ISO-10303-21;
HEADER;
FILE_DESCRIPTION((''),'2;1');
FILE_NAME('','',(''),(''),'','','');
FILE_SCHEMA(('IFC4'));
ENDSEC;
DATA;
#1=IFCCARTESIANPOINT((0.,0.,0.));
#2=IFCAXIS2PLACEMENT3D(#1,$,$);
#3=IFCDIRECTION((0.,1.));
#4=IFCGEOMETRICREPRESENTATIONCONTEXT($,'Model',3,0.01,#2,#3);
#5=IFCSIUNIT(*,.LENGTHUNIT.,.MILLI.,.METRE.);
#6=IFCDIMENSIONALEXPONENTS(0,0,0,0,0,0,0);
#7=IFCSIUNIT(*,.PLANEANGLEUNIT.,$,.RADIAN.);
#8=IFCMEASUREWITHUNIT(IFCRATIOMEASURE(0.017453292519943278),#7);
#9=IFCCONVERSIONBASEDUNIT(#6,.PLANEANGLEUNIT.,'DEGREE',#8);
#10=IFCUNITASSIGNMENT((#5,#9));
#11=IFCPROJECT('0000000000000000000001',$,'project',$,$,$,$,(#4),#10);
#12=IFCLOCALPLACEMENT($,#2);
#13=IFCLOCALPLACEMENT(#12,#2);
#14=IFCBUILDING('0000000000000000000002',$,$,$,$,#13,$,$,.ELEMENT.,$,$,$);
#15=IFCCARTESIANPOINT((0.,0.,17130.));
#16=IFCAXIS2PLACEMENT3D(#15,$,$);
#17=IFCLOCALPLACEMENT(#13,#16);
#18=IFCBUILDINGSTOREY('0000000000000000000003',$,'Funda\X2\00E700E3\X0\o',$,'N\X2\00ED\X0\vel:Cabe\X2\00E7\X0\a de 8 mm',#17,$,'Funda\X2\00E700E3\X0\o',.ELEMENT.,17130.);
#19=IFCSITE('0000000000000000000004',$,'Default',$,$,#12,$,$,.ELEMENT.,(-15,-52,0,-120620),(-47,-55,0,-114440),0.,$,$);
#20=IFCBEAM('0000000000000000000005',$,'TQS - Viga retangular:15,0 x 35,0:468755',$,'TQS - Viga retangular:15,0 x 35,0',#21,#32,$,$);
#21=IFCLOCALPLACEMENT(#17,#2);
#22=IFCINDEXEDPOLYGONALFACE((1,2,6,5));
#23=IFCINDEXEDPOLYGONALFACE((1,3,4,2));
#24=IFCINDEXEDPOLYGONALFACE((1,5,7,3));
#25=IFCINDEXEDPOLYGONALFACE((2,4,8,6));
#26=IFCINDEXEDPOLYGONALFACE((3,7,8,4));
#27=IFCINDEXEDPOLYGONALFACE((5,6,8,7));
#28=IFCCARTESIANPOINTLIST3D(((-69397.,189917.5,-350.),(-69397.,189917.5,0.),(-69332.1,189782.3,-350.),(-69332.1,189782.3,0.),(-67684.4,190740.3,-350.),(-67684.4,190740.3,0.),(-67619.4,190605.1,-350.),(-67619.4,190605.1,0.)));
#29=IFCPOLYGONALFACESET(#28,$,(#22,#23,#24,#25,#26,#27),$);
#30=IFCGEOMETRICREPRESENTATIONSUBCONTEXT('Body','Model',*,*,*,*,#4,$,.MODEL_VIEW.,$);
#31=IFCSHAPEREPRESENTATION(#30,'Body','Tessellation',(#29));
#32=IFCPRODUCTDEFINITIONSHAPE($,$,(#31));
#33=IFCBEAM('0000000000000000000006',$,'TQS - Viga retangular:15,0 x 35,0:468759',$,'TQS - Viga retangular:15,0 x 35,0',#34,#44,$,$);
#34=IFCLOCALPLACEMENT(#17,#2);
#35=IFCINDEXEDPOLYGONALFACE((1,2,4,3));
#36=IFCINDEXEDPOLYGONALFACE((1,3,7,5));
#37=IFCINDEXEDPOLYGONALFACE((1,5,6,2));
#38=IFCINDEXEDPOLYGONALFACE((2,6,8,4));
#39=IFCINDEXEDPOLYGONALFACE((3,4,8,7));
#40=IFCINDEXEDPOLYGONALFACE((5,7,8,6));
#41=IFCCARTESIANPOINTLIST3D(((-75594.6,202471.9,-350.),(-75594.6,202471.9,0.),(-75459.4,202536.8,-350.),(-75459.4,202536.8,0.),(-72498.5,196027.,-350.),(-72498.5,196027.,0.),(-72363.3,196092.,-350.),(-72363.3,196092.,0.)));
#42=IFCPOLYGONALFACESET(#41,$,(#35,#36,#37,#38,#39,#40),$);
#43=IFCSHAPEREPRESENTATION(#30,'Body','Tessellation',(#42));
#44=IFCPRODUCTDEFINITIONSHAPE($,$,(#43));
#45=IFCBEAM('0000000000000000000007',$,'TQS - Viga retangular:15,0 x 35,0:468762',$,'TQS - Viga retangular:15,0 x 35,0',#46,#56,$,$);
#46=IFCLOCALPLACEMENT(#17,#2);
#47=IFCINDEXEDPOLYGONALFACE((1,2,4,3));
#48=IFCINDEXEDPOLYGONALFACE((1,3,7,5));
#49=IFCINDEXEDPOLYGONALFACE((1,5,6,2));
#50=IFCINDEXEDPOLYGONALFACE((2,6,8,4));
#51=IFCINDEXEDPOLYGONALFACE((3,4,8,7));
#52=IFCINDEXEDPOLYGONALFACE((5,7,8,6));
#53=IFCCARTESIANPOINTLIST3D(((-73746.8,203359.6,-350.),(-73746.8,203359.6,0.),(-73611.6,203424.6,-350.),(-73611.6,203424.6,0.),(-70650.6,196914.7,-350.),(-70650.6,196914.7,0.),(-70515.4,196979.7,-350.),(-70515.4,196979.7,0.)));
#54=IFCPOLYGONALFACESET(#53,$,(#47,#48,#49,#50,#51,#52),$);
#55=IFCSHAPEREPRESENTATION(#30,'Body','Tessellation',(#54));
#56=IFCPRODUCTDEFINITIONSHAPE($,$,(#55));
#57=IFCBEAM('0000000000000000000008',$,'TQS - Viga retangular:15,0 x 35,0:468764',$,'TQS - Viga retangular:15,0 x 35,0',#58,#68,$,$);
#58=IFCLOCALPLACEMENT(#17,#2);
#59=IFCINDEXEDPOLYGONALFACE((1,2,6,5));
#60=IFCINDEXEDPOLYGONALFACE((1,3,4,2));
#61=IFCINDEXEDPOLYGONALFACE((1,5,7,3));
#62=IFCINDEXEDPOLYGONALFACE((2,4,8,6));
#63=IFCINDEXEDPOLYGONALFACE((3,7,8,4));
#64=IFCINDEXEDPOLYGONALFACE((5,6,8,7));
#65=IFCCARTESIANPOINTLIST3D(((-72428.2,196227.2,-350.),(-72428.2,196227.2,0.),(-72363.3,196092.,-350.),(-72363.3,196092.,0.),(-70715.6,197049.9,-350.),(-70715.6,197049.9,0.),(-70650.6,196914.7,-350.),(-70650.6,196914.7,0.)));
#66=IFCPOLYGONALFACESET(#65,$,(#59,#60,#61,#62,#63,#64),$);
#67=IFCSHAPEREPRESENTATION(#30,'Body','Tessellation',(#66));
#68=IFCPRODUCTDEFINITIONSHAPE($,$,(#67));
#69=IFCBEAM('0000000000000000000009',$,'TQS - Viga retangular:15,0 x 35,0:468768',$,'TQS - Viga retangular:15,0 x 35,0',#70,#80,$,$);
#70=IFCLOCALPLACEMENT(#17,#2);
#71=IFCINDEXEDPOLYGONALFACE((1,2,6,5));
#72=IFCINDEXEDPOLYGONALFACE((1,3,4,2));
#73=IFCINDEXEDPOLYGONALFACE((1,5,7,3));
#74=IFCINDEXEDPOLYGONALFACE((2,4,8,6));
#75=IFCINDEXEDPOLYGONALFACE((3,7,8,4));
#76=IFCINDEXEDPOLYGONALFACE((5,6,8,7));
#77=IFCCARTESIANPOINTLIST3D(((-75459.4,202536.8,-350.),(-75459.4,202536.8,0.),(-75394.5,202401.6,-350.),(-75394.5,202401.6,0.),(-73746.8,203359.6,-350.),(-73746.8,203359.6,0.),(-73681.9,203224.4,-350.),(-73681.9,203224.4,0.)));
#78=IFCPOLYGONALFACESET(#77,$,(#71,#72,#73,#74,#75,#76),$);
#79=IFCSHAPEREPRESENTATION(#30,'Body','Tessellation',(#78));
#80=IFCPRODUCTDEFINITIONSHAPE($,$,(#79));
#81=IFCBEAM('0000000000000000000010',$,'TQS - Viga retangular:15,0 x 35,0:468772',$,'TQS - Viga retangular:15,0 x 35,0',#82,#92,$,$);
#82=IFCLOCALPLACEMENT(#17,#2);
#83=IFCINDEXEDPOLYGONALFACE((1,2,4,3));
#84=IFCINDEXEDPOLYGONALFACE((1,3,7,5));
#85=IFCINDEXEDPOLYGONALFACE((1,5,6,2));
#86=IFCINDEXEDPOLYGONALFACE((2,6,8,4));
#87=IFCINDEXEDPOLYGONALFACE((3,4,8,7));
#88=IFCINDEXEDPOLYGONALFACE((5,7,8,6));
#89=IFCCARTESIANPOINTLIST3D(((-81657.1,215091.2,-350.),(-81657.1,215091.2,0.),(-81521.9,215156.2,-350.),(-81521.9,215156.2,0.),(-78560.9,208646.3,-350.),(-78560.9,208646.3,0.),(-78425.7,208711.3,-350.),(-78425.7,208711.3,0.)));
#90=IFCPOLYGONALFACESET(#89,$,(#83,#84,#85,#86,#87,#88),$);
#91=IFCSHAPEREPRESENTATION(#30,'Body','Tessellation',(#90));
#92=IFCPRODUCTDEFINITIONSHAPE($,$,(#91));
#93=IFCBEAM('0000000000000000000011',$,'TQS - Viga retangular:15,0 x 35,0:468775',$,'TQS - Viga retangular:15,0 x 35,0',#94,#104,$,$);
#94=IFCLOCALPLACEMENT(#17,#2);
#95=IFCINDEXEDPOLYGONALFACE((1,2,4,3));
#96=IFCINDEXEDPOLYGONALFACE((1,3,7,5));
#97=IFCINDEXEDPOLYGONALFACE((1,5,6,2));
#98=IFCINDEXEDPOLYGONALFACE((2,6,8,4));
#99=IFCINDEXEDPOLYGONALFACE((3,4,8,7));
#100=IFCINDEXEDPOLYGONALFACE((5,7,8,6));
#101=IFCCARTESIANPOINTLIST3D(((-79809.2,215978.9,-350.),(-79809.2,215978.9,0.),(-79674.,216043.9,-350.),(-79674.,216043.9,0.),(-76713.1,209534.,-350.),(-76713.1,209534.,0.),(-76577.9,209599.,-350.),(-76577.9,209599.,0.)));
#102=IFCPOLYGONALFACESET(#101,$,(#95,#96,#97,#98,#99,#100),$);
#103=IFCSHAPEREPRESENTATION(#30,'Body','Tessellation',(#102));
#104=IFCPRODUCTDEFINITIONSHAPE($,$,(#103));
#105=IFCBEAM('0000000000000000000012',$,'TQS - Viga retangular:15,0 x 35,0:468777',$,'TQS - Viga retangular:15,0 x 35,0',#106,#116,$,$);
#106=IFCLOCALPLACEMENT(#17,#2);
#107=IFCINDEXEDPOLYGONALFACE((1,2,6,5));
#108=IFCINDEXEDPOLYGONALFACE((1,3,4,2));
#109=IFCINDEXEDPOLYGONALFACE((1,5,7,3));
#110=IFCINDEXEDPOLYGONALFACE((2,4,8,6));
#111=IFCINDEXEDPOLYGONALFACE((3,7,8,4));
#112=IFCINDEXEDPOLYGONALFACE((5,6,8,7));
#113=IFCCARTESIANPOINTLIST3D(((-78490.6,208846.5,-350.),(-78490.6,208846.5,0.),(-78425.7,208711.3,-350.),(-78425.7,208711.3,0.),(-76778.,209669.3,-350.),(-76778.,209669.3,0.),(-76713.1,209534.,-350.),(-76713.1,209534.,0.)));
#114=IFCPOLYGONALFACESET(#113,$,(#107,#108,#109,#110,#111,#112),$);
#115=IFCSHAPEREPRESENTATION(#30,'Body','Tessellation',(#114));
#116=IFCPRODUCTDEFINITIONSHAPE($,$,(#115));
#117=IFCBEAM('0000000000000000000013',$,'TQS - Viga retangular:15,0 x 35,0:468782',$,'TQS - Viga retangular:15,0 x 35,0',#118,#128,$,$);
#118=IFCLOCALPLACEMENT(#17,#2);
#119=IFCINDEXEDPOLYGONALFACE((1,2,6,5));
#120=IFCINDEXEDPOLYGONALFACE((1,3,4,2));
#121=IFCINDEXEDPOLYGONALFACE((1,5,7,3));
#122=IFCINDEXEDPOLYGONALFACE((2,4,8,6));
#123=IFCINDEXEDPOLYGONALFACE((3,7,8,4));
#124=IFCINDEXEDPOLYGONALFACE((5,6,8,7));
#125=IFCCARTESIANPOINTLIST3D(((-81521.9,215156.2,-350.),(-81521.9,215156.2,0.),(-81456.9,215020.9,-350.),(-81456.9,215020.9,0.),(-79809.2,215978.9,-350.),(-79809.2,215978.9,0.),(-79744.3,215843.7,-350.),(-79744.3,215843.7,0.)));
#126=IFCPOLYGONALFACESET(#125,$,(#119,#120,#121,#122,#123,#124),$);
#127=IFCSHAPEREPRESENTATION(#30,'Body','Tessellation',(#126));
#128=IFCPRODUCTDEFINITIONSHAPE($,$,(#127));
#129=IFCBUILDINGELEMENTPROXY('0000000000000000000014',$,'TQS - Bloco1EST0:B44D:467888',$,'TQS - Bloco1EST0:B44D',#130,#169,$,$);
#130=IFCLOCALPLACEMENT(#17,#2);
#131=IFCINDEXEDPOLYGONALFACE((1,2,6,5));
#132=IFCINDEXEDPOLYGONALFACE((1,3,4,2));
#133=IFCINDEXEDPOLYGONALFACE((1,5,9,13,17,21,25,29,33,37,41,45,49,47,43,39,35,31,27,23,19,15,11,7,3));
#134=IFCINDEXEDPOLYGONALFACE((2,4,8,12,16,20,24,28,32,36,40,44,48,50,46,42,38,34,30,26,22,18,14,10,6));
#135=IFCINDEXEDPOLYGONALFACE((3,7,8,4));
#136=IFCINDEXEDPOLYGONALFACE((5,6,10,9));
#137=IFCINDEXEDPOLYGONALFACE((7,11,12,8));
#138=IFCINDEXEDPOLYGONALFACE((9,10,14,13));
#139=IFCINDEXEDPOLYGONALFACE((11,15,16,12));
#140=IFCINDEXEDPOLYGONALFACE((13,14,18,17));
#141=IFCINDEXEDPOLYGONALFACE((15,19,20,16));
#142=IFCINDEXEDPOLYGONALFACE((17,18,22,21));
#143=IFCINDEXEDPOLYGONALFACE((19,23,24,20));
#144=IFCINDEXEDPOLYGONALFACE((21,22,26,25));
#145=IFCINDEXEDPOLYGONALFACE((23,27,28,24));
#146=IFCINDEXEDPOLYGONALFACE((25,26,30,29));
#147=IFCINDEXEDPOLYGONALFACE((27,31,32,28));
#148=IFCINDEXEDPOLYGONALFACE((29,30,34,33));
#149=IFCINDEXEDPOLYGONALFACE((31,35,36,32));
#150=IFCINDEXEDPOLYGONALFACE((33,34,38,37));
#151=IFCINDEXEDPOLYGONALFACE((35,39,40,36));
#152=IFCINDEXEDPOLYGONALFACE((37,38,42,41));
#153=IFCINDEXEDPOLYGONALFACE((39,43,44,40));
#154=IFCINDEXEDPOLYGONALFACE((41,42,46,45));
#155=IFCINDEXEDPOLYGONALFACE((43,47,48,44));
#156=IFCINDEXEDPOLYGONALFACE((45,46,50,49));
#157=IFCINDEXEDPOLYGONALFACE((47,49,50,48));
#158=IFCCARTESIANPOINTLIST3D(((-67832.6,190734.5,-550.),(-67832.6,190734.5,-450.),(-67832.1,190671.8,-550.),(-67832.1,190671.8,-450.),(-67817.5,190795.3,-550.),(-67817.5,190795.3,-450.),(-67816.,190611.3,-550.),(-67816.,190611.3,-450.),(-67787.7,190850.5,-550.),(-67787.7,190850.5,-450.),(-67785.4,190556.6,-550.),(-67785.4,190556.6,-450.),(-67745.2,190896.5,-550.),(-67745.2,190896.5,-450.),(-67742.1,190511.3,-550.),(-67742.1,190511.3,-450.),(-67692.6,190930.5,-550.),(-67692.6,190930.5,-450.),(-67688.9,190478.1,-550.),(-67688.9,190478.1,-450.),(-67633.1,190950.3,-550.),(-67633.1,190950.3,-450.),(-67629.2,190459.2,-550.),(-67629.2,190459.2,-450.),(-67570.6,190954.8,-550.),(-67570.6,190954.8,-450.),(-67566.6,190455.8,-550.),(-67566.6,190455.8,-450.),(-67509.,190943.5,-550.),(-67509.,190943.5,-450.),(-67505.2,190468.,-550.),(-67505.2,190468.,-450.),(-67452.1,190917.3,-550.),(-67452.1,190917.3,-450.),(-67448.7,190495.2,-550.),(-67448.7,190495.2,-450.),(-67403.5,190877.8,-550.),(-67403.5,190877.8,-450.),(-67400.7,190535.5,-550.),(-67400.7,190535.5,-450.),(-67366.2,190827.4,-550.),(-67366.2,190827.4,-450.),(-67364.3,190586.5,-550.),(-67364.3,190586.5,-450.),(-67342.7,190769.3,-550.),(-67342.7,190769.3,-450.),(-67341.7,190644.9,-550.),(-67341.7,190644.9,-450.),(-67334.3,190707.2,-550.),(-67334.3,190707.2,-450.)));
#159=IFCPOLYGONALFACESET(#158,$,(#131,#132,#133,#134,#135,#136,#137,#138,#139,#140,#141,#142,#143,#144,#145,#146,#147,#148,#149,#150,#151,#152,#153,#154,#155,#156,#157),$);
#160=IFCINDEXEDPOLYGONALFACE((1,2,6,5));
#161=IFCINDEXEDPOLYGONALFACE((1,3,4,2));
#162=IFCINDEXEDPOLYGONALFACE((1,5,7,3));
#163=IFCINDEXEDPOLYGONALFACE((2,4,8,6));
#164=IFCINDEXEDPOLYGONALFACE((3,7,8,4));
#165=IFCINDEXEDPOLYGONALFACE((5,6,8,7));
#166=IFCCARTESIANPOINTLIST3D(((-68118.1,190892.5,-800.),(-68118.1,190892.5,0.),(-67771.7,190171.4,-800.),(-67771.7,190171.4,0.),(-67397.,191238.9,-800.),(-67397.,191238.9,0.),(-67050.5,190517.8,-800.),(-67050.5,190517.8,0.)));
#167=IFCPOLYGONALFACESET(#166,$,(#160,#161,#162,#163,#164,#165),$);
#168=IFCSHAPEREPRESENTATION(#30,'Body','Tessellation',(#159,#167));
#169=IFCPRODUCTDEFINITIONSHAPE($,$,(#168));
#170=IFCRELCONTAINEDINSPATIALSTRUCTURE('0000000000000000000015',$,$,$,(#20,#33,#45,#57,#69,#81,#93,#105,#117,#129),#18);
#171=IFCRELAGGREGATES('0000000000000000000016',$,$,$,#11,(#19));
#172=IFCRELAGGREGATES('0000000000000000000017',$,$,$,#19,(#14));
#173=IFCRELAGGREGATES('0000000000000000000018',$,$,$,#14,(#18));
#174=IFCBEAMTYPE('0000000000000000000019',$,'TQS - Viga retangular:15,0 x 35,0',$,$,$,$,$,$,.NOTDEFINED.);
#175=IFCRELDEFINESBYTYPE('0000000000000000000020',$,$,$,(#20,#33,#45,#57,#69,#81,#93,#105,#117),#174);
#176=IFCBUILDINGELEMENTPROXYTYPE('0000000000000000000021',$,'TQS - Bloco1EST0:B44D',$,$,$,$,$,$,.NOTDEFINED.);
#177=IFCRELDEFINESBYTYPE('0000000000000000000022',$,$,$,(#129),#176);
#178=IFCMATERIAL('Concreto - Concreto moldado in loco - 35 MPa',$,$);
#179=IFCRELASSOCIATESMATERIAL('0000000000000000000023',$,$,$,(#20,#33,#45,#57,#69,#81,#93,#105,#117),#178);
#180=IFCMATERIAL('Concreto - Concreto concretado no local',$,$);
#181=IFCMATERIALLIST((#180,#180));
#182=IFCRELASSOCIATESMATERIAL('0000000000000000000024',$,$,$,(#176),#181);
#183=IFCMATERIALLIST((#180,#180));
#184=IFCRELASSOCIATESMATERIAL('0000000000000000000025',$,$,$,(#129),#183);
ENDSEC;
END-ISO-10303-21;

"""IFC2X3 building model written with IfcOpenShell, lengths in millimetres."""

from ifc_helpers import new_model, entity, si_unit, converted_unit, direction, frame, frame_2d, origin, origin_2d_with_axis, place, context, subcontext, project, spatial, rectangle, circle, extrude, source, transform, mapped, material, material_list, type_object, type_shapes, element, save


model = new_model("IFC2X3")

# Units and contexts
model_context = context("Model", 3, precision=0.01, world=origin(), true_north=direction((0.0, 1.0)))
body_context = subcontext(model_context, "Body", "Model", "MODEL_VIEW")
ifc_project = project(units=[si_unit("LENGTHUNIT", "METRE", prefix="MILLI"), converted_unit("PLANEANGLEUNIT", "DEGREE", entity("IfcRatioMeasure", 0.017453292519943278), si_unit("PLANEANGLEUNIT", "RADIAN"), dimensions=[0, 0, 0, 0, 0, 0, 0])], contexts=[model_context])

# Site, building, storey
site_placement = place(None, origin())
site = spatial("IfcSite", under=ifc_project, at=site_placement, Name="Default", CompositionType="ELEMENT", RefLatitude=(-15, -52, 0, -120620), RefLongitude=(-47, -55, 0, -114440), RefElevation=0.0)
building_placement = place(site_placement, origin())
building = spatial("IfcBuilding", under=site, at=building_placement, CompositionType="ELEMENT")
storey_placement = place(building_placement, frame((0.0, 0.0, 17130.0)))
storey = spatial("IfcBuildingStorey", under=building, at=storey_placement, Name="Fundação", ObjectType="Nível:Cabeça de 8 mm", LongName="Fundação", CompositionType="ELEMENT", Elevation=17130.0)

# Beams
ifc_material_1 = material(Name="Concreto - Concreto moldado in loco - 35 MPa")
beam_type = type_object("IfcBeamType", Name="TQS - Viga retangular:15,0 x 35,0", PredefinedType="NOTDEFINED")
beam_1_placement = place(storey_placement, frame((-67584.3, 190705.2, 0.0), z_axis=(0.0, 0.0, 1.0), x_axis=(-0.90138, -0.43303, 0.0)))
element("IfcBeam", 1, at=beam_1_placement, inside=storey, type_object=beam_type, material=ifc_material_1, Name="TQS - Viga retangular:15,0 x 35,0:468755", ObjectType="TQS - Viga retangular:15,0 x 35,0", context=body_context, shape_type="SweptSolid", body=[
    extrude(rectangle(XDim=350.0, YDim=150.0, at=frame_2d((0.0, 0.0), x_axis=(1.0, 0.0))), frame((75.0, 0.0, -175.0), z_axis=(1.0, 0.0, 0.0), x_axis=(0.0, 0.0, -1.0)), (0.0, 0.0, 1.0), 1900.0),
])
beam_2_placement = place(storey_placement, frame((-72463.4, 196127.1, 0.0), z_axis=(0.0, 0.0, 1.0), x_axis=(-0.43303, 0.90138, 0.0)))
element("IfcBeam", 2, at=beam_2_placement, inside=storey, type_object=beam_type, material=ifc_material_1, Name="TQS - Viga retangular:15,0 x 35,0:468759", ObjectType="TQS - Viga retangular:15,0 x 35,0", context=body_context, shape_type="SweptSolid", body=[
    extrude(rectangle(XDim=350.0, YDim=150.0, at=frame_2d((0.0, 0.0), x_axis=(1.0, 0.0))), frame((-75.0, 0.0, -175.0), z_axis=(1.0, 0.0, 0.0), x_axis=(0.0, 0.0, -1.0)), (0.0, 0.0, 1.0), 7150.0),
])
beam_3_placement = place(storey_placement, frame((-70615.5, 197014.8, 0.0), z_axis=(0.0, 0.0, 1.0), x_axis=(-0.43303, 0.90138, 0.0)))
element("IfcBeam", 3, at=beam_3_placement, inside=storey, type_object=beam_type, material=ifc_material_1, Name="TQS - Viga retangular:15,0 x 35,0:468762", ObjectType="TQS - Viga retangular:15,0 x 35,0", context=body_context, shape_type="SweptSolid", body=[
    extrude(rectangle(XDim=350.0, YDim=150.0, at=frame_2d((0.0, 0.0), x_axis=(1.0, 0.0))), frame((-75.0, 0.0, -175.0), z_axis=(1.0, 0.0, 0.0), x_axis=(0.0, 0.0, -1.0)), (0.0, 0.0, 1.0), 7150.0),
])
beam_4_placement = place(storey_placement, frame((-70615.5, 197014.8, 0.0), z_axis=(0.0, 0.0, 1.0), x_axis=(-0.90138, -0.43303, 0.0)))
element("IfcBeam", 4, at=beam_4_placement, inside=storey, type_object=beam_type, material=ifc_material_1, Name="TQS - Viga retangular:15,0 x 35,0:468764", ObjectType="TQS - Viga retangular:15,0 x 35,0", context=body_context, shape_type="SweptSolid", body=[
    extrude(rectangle(XDim=350.0, YDim=150.0, at=frame_2d((0.0, 0.0), x_axis=(1.0, 0.0))), frame((75.0, 0.0, -175.0), z_axis=(1.0, 0.0, 0.0), x_axis=(0.0, 0.0, -1.0)), (0.0, 0.0, 1.0), 1900.0),
])
beam_5_placement = place(storey_placement, frame((-73646.7, 203324.5, 0.0), z_axis=(0.0, 0.0, 1.0), x_axis=(-0.90138, -0.43303, 0.0)))
element("IfcBeam", 5, at=beam_5_placement, inside=storey, type_object=beam_type, material=ifc_material_1, Name="TQS - Viga retangular:15,0 x 35,0:468768", ObjectType="TQS - Viga retangular:15,0 x 35,0", context=body_context, shape_type="SweptSolid", body=[
    extrude(rectangle(XDim=350.0, YDim=150.0, at=frame_2d((0.0, 0.0), x_axis=(1.0, 0.0))), frame((75.0, 0.0, -175.0), z_axis=(1.0, 0.0, 0.0), x_axis=(0.0, 0.0, -1.0)), (0.0, 0.0, 1.0), 1900.0),
])
beam_6_placement = place(storey_placement, frame((-78525.8, 208746.4, 0.0), z_axis=(0.0, 0.0, 1.0), x_axis=(-0.43303, 0.90138, 0.0)))
element("IfcBeam", 6, at=beam_6_placement, inside=storey, type_object=beam_type, material=ifc_material_1, Name="TQS - Viga retangular:15,0 x 35,0:468772", ObjectType="TQS - Viga retangular:15,0 x 35,0", context=body_context, shape_type="SweptSolid", body=[
    extrude(rectangle(XDim=350.0, YDim=150.0, at=frame_2d((0.0, 0.0), x_axis=(1.0, 0.0))), frame((-75.0, 0.0, -175.0), z_axis=(1.0, 0.0, 0.0), x_axis=(0.0, 0.0, -1.0)), (0.0, 0.0, 1.0), 7150.0),
])
beam_7_placement = place(storey_placement, frame((-76677.9, 209634.1, 0.0), z_axis=(0.0, 0.0, 1.0), x_axis=(-0.43303, 0.90138, 0.0)))
element("IfcBeam", 7, at=beam_7_placement, inside=storey, type_object=beam_type, material=ifc_material_1, Name="TQS - Viga retangular:15,0 x 35,0:468775", ObjectType="TQS - Viga retangular:15,0 x 35,0", context=body_context, shape_type="SweptSolid", body=[
    extrude(rectangle(XDim=350.0, YDim=150.0, at=frame_2d((0.0, 0.0), x_axis=(1.0, 0.0))), frame((-75.0, 0.0, -175.0), z_axis=(1.0, 0.0, 0.0), x_axis=(0.0, 0.0, -1.0)), (0.0, 0.0, 1.0), 7150.0),
])
beam_8_placement = place(storey_placement, frame((-76677.9, 209634.1, 0.0), z_axis=(0.0, 0.0, 1.0), x_axis=(-0.90138, -0.43303, 0.0)))
element("IfcBeam", 8, at=beam_8_placement, inside=storey, type_object=beam_type, material=ifc_material_1, Name="TQS - Viga retangular:15,0 x 35,0:468777", ObjectType="TQS - Viga retangular:15,0 x 35,0", context=body_context, shape_type="SweptSolid", body=[
    extrude(rectangle(XDim=350.0, YDim=150.0, at=frame_2d((0.0, 0.0), x_axis=(1.0, 0.0))), frame((75.0, 0.0, -175.0), z_axis=(1.0, 0.0, 0.0), x_axis=(0.0, 0.0, -1.0)), (0.0, 0.0, 1.0), 1900.0),
])
beam_9_placement = place(storey_placement, frame((-79709.2, 215943.8, 0.0), z_axis=(0.0, 0.0, 1.0), x_axis=(-0.90138, -0.43303, 0.0)))
element("IfcBeam", 9, at=beam_9_placement, inside=storey, type_object=beam_type, material=ifc_material_1, Name="TQS - Viga retangular:15,0 x 35,0:468782", ObjectType="TQS - Viga retangular:15,0 x 35,0", context=body_context, shape_type="SweptSolid", body=[
    extrude(rectangle(XDim=350.0, YDim=150.0, at=frame_2d((0.0, 0.0), x_axis=(1.0, 0.0))), frame((75.0, 0.0, -175.0), z_axis=(1.0, 0.0, 0.0), x_axis=(0.0, 0.0, -1.0)), (0.0, 0.0, 1.0), 1900.0),
])

# Building element proxy
ifc_material_2 = material(Name="Concreto - Concreto concretado no local")
ifc_material_list_1 = material_list([ifc_material_2, ifc_material_2])
ifc_material_list_2 = material_list([ifc_material_2, ifc_material_2])
building_element_proxy_type_1 = type_object("IfcBuildingElementProxyType", Name="TQS - Bloco1EST0:B44D", PredefinedType="NOTDEFINED", material=ifc_material_list_2)
shared_shape_1 = source(origin(), body_context, "Body", "SweptSolid", [
    extrude(circle(Radius=250.0, at=frame_2d((0.0, 0.0), x_axis=(1.0, 0.0))), frame((0.0, 0.0, -550.0)), (0.0, 0.0, 1.0), 100.0),
    extrude(rectangle(XDim=800.0, YDim=800.0, at=origin_2d_with_axis()), frame((0.0, 0.0, -800.0), z_axis=(0.0, 0.0, 1.0), x_axis=(-1.0, 0.0, 0.0)), (0.0, 0.0, 1.0), 800.0),
])
type_shapes(building_element_proxy_type_1, [shared_shape_1])
proxy_1_placement = place(storey_placement, frame((-67584.3, 190705.2, 0.0), z_axis=(0.0, 0.0, 1.0), x_axis=(-0.43303, 0.90138, 0.0)))
element("IfcBuildingElementProxy", 10, at=proxy_1_placement, inside=storey, type_object=building_element_proxy_type_1, material=ifc_material_list_1, Name="TQS - Bloco1EST0:B44D:467888", ObjectType="TQS - Bloco1EST0:B44D", context=body_context, shape_type="MappedRepresentation", body=[
    mapped(shared_shape_1, transform((0.0, 0.0, 0.0), scale=1.0)),
])

save(model, "model.ifc")
